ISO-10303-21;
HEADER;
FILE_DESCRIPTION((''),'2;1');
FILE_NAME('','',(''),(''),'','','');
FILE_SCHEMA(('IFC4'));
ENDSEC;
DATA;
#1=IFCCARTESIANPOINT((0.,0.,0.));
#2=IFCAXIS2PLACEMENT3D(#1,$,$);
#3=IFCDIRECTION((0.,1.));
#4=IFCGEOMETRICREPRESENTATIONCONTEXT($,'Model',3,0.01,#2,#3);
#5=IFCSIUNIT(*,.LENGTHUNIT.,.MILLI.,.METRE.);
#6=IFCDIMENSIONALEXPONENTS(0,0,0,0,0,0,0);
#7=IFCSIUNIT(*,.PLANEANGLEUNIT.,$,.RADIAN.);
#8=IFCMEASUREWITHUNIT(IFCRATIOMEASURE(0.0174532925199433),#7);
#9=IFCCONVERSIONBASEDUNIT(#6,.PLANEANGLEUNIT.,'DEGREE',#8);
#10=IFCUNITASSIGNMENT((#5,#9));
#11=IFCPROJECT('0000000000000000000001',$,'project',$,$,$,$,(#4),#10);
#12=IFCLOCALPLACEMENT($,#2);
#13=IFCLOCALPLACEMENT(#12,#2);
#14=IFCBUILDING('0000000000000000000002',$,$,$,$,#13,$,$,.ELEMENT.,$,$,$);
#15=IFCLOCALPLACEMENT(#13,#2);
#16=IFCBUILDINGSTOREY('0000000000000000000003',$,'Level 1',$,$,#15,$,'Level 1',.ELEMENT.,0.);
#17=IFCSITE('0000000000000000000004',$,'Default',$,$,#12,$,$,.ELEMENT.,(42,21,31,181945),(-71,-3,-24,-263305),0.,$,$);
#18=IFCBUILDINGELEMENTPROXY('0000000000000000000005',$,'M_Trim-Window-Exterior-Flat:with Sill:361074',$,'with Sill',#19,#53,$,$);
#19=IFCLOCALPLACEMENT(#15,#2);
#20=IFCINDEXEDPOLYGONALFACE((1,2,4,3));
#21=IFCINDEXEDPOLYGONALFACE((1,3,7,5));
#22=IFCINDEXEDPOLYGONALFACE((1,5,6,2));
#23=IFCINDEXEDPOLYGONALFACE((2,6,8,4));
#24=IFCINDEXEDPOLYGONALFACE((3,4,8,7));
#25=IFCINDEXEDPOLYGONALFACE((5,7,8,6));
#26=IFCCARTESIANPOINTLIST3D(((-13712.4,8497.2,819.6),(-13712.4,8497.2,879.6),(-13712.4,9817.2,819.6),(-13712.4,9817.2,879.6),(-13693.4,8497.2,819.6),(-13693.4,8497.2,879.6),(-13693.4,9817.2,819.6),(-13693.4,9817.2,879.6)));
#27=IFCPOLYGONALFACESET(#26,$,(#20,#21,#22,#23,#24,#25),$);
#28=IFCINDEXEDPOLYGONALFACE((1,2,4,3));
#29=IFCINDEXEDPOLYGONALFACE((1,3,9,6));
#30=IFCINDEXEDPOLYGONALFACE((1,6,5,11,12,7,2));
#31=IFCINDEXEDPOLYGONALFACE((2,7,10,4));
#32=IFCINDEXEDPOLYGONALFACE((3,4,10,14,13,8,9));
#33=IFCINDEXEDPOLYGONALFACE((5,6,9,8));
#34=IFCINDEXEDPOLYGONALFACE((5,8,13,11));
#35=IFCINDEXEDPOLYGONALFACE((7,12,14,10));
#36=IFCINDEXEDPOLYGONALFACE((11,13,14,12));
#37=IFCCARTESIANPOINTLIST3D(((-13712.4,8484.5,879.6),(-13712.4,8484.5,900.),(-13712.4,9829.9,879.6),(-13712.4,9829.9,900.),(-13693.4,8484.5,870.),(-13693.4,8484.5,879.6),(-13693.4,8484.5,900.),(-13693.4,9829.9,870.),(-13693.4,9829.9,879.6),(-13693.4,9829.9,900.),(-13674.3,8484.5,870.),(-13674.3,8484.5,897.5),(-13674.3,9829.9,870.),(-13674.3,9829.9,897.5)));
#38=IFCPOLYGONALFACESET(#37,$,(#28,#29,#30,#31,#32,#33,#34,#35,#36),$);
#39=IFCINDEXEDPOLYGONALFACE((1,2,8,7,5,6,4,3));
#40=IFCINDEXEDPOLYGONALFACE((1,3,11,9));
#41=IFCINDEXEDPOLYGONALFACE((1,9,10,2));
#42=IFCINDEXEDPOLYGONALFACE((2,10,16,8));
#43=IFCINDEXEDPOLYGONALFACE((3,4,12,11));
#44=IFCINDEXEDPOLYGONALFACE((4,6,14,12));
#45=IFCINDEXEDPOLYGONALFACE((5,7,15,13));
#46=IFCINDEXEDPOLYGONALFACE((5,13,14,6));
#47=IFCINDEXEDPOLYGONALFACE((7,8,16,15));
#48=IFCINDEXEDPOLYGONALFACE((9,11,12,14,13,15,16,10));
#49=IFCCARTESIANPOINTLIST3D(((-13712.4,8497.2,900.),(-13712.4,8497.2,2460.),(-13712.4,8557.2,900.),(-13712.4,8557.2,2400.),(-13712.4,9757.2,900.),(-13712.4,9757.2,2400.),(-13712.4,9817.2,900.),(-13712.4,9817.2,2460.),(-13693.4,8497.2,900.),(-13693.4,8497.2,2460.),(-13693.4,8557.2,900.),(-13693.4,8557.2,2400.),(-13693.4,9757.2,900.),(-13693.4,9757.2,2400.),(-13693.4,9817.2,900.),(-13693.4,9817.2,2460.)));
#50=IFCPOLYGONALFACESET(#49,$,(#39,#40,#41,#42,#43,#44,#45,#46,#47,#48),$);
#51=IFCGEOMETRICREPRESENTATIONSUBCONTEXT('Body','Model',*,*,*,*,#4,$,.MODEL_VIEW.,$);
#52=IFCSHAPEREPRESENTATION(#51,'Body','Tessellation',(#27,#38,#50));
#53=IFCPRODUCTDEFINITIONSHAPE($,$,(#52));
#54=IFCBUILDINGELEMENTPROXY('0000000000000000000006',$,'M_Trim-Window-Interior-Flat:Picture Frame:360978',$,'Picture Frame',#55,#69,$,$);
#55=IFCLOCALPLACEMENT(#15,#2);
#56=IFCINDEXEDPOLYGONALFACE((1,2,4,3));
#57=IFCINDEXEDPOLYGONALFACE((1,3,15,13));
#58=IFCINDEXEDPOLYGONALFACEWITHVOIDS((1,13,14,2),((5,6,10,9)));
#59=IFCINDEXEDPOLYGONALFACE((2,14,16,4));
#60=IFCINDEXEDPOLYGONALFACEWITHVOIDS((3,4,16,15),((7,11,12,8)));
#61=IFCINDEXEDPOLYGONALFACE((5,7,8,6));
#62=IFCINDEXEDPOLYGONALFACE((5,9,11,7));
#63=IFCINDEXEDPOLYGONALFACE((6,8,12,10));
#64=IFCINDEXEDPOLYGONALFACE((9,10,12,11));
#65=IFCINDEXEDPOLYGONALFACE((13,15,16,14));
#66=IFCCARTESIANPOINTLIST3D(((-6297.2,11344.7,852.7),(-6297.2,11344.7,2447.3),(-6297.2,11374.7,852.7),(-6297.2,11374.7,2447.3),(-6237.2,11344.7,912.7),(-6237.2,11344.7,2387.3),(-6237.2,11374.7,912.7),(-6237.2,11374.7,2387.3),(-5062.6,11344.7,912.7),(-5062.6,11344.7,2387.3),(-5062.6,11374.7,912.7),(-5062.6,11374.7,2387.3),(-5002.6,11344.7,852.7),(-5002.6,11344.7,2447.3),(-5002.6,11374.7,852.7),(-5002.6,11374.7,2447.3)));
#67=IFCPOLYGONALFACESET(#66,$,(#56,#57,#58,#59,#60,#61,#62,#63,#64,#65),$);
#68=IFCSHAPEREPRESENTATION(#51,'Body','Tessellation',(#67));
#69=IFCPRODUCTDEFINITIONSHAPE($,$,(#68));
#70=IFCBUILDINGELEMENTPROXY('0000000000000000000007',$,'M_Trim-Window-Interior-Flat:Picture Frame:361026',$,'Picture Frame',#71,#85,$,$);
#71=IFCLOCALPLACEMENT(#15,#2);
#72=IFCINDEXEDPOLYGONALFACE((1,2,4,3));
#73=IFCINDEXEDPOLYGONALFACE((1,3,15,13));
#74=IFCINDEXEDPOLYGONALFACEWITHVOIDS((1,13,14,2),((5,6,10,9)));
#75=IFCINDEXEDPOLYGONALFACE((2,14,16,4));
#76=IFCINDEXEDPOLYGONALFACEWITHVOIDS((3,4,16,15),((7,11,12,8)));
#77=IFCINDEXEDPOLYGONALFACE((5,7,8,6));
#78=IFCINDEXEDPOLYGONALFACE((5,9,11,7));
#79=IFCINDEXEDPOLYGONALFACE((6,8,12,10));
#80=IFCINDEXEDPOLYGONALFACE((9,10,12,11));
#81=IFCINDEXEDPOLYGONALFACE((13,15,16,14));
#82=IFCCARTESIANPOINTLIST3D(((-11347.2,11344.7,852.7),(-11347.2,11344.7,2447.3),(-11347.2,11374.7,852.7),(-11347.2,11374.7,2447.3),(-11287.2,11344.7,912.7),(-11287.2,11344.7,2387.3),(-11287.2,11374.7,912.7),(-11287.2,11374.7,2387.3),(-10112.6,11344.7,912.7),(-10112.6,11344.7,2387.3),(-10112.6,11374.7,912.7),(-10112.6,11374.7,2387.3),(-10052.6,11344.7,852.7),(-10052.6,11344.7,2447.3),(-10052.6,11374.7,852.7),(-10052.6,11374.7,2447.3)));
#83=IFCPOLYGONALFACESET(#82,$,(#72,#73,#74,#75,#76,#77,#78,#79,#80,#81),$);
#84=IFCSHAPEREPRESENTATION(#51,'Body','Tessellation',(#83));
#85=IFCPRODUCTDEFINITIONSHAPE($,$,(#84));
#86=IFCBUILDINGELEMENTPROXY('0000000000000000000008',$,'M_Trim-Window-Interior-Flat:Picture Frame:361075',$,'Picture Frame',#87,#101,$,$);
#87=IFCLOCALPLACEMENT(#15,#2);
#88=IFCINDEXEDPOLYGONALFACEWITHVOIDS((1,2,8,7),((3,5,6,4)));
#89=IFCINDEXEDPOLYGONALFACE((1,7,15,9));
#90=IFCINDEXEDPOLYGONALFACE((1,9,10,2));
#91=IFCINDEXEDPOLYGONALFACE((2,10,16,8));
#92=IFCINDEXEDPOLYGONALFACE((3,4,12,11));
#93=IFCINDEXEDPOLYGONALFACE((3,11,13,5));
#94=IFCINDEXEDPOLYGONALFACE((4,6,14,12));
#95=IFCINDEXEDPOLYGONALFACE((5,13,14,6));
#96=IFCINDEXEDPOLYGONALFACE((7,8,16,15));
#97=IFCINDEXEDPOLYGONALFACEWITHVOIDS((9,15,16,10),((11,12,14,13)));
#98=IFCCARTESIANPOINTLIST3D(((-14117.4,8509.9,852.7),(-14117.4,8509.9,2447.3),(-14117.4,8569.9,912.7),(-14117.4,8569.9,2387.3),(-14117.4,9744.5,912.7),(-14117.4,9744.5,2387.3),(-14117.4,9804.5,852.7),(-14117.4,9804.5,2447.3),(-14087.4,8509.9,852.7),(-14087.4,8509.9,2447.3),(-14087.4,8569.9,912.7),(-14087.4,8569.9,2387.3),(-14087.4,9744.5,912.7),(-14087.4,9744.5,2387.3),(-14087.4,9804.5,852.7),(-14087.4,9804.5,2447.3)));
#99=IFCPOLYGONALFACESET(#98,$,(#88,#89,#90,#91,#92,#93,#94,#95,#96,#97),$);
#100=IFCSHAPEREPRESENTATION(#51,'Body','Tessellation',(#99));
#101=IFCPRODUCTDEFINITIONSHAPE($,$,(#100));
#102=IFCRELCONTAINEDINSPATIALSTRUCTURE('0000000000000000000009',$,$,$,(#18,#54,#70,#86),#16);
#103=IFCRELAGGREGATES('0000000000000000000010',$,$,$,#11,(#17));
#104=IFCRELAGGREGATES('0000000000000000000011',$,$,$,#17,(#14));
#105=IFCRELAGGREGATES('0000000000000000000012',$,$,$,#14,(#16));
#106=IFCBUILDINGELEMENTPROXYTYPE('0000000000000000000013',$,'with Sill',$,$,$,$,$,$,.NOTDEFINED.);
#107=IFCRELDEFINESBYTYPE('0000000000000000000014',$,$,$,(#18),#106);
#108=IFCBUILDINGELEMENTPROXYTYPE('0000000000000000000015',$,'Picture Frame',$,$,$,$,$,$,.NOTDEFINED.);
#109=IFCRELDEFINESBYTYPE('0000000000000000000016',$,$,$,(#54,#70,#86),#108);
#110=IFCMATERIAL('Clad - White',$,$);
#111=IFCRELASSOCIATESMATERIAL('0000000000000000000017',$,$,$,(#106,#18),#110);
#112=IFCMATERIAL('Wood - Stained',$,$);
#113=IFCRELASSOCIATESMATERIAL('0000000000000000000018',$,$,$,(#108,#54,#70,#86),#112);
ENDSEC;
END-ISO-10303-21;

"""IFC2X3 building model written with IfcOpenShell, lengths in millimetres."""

from ifc_helpers import new_model, entity, si_unit, converted_unit, direction, frame, frame_2d, origin, place, context, subcontext, project, spatial, polyline, rectangle, outline, extrude, source, transform, mapped, material, type_object, type_shapes, element, save


model = new_model("IFC2X3")

# Units and contexts
model_context = context("Model", 3, precision=0.01, world=origin(), true_north=direction((0.0, 1.0)))
body_context = subcontext(model_context, "Body", "Model", "MODEL_VIEW")
ifc_project = project(units=[si_unit("LENGTHUNIT", "METRE", prefix="MILLI"), converted_unit("PLANEANGLEUNIT", "DEGREE", entity("IfcRatioMeasure", 0.0174532925199433), si_unit("PLANEANGLEUNIT", "RADIAN"), dimensions=[0, 0, 0, 0, 0, 0, 0])], contexts=[model_context])

# Site, building, storey
site_placement = place(None, origin())
site = spatial("IfcSite", under=ifc_project, at=site_placement, Name="Default", CompositionType="ELEMENT", RefLatitude=(42, 21, 31, 181945), RefLongitude=(-71, -3, -24, -263305), RefElevation=0.0)
building_placement = place(site_placement, origin())
building = spatial("IfcBuilding", under=site, at=building_placement, CompositionType="ELEMENT")
storey_placement = place(building_placement, origin())
storey = spatial("IfcBuildingStorey", under=building, at=storey_placement, Name="Level 1", LongName="Level 1", CompositionType="ELEMENT", Elevation=0.0)

# Building element proxies
ifc_material_1 = material(Name="Clad - White")
ifc_material_2 = material(Name="Wood - Stained")
building_element_proxy_type_1 = type_object("IfcBuildingElementProxyType", Name="with Sill", PredefinedType="NOTDEFINED", material=ifc_material_1)
shared_shape_1 = source(origin(), body_context, "Body", "SweptSolid", [
    extrude(rectangle(XDim=1320.0, YDim=60.0, at=frame_2d((0.0, 0.0), x_axis=(1.0, 0.0))), frame((0.0, -1550.4, 0.0), z_axis=(0.0, 0.0, 1.0), x_axis=(-1.0, 0.0, 0.0)), (0.0, 0.0, 1.0), 19.1),
    extrude(outline(polyline([(-19.0, -15.2), (0.0, -15.2), (0.0, -5.7), (19.0, -5.7), (19.0, 14.8), (0.0, 14.8), (-19.0, 12.3), (-19.0, -15.2)])), frame((-672.7, -1514.8, 19.0), z_axis=(1.0, 0.0, 0.0), x_axis=(0.0, 0.0, -1.0)), (0.0, 0.0, 1.0), 1345.4),
    extrude(outline(polyline([(-795.0, -660.0), (765.0, -660.0), (765.0, -600.0), (-735.0, -600.0), (-735.0, 600.0), (765.0, 600.0), (765.0, 660.0), (-795.0, 660.0), (-795.0, -660.0)])), frame((0.0, -735.0, 0.0), z_axis=(0.0, 0.0, 1.0), x_axis=(0.0, -1.0, 0.0)), (0.0, 0.0, 1.0), 19.1),
])
type_shapes(building_element_proxy_type_1, [shared_shape_1])
for number, where, z_axis, x_axis, name in (
    (1, (-13712.4, 9157.2, 2400.0), (1.0, 0.0, 0.0), (0.0, 1.0, 0.0), "M_Trim-Window-Exterior-Flat:with Sill:361074"),
):
    element("IfcBuildingElementProxy", number, at=place(storey_placement, frame(where, z_axis=z_axis, x_axis=x_axis)), inside=storey, type_object=building_element_proxy_type_1, material=ifc_material_1, Name=name, ObjectType="with Sill", context=body_context, shape_type="MappedRepresentation", body=[
        mapped(shared_shape_1, transform((0.0, 0.0, 0.0), scale=1.0)),
    ])
building_element_proxy_type_2 = type_object("IfcBuildingElementProxyType", Name="Picture Frame", PredefinedType="NOTDEFINED", material=ifc_material_2)
shared_shape_2 = source(origin(), body_context, "Body", "SweptSolid", [
    extrude(outline(polyline([(-647.3, -797.3), (647.3, -797.3), (647.3, 797.3), (-647.3, 797.3), (-647.3, -797.3)]), holes=[polyline([(-587.3, -737.3), (-587.3, 737.3), (587.3, 737.3), (587.3, -737.3), (-587.3, -737.3)])]), frame((0.0, -750.0, 0.0), z_axis=(0.0, 0.0, 1.0), x_axis=(-1.0, 0.0, 0.0)), (0.0, 0.0, 1.0), 30.0),
])
type_shapes(building_element_proxy_type_2, [shared_shape_2])
for number, where, z_axis, x_axis, name in (
    (2, (-5649.9, 11344.7, 2400.0), (0.0, 1.0, 0.0), (-1.0, 0.0, 0.0), "M_Trim-Window-Interior-Flat:Picture Frame:360978"),
    (3, (-10699.9, 11344.7, 2400.0), (0.0, 1.0, 0.0), (-1.0, 0.0, 0.0), "M_Trim-Window-Interior-Flat:Picture Frame:361026"),
    (4, (-14087.4, 9157.2, 2400.0), (-1.0, 0.0, 0.0), (0.0, -1.0, 0.0), "M_Trim-Window-Interior-Flat:Picture Frame:361075"),
):
    element("IfcBuildingElementProxy", number, at=place(storey_placement, frame(where, z_axis=z_axis, x_axis=x_axis)), inside=storey, type_object=building_element_proxy_type_2, material=ifc_material_2, Name=name, ObjectType="Picture Frame", context=body_context, shape_type="MappedRepresentation", body=[
        mapped(shared_shape_2, transform((0.0, 0.0, 0.0), scale=1.0)),
    ])

save(model, "model.ifc")
